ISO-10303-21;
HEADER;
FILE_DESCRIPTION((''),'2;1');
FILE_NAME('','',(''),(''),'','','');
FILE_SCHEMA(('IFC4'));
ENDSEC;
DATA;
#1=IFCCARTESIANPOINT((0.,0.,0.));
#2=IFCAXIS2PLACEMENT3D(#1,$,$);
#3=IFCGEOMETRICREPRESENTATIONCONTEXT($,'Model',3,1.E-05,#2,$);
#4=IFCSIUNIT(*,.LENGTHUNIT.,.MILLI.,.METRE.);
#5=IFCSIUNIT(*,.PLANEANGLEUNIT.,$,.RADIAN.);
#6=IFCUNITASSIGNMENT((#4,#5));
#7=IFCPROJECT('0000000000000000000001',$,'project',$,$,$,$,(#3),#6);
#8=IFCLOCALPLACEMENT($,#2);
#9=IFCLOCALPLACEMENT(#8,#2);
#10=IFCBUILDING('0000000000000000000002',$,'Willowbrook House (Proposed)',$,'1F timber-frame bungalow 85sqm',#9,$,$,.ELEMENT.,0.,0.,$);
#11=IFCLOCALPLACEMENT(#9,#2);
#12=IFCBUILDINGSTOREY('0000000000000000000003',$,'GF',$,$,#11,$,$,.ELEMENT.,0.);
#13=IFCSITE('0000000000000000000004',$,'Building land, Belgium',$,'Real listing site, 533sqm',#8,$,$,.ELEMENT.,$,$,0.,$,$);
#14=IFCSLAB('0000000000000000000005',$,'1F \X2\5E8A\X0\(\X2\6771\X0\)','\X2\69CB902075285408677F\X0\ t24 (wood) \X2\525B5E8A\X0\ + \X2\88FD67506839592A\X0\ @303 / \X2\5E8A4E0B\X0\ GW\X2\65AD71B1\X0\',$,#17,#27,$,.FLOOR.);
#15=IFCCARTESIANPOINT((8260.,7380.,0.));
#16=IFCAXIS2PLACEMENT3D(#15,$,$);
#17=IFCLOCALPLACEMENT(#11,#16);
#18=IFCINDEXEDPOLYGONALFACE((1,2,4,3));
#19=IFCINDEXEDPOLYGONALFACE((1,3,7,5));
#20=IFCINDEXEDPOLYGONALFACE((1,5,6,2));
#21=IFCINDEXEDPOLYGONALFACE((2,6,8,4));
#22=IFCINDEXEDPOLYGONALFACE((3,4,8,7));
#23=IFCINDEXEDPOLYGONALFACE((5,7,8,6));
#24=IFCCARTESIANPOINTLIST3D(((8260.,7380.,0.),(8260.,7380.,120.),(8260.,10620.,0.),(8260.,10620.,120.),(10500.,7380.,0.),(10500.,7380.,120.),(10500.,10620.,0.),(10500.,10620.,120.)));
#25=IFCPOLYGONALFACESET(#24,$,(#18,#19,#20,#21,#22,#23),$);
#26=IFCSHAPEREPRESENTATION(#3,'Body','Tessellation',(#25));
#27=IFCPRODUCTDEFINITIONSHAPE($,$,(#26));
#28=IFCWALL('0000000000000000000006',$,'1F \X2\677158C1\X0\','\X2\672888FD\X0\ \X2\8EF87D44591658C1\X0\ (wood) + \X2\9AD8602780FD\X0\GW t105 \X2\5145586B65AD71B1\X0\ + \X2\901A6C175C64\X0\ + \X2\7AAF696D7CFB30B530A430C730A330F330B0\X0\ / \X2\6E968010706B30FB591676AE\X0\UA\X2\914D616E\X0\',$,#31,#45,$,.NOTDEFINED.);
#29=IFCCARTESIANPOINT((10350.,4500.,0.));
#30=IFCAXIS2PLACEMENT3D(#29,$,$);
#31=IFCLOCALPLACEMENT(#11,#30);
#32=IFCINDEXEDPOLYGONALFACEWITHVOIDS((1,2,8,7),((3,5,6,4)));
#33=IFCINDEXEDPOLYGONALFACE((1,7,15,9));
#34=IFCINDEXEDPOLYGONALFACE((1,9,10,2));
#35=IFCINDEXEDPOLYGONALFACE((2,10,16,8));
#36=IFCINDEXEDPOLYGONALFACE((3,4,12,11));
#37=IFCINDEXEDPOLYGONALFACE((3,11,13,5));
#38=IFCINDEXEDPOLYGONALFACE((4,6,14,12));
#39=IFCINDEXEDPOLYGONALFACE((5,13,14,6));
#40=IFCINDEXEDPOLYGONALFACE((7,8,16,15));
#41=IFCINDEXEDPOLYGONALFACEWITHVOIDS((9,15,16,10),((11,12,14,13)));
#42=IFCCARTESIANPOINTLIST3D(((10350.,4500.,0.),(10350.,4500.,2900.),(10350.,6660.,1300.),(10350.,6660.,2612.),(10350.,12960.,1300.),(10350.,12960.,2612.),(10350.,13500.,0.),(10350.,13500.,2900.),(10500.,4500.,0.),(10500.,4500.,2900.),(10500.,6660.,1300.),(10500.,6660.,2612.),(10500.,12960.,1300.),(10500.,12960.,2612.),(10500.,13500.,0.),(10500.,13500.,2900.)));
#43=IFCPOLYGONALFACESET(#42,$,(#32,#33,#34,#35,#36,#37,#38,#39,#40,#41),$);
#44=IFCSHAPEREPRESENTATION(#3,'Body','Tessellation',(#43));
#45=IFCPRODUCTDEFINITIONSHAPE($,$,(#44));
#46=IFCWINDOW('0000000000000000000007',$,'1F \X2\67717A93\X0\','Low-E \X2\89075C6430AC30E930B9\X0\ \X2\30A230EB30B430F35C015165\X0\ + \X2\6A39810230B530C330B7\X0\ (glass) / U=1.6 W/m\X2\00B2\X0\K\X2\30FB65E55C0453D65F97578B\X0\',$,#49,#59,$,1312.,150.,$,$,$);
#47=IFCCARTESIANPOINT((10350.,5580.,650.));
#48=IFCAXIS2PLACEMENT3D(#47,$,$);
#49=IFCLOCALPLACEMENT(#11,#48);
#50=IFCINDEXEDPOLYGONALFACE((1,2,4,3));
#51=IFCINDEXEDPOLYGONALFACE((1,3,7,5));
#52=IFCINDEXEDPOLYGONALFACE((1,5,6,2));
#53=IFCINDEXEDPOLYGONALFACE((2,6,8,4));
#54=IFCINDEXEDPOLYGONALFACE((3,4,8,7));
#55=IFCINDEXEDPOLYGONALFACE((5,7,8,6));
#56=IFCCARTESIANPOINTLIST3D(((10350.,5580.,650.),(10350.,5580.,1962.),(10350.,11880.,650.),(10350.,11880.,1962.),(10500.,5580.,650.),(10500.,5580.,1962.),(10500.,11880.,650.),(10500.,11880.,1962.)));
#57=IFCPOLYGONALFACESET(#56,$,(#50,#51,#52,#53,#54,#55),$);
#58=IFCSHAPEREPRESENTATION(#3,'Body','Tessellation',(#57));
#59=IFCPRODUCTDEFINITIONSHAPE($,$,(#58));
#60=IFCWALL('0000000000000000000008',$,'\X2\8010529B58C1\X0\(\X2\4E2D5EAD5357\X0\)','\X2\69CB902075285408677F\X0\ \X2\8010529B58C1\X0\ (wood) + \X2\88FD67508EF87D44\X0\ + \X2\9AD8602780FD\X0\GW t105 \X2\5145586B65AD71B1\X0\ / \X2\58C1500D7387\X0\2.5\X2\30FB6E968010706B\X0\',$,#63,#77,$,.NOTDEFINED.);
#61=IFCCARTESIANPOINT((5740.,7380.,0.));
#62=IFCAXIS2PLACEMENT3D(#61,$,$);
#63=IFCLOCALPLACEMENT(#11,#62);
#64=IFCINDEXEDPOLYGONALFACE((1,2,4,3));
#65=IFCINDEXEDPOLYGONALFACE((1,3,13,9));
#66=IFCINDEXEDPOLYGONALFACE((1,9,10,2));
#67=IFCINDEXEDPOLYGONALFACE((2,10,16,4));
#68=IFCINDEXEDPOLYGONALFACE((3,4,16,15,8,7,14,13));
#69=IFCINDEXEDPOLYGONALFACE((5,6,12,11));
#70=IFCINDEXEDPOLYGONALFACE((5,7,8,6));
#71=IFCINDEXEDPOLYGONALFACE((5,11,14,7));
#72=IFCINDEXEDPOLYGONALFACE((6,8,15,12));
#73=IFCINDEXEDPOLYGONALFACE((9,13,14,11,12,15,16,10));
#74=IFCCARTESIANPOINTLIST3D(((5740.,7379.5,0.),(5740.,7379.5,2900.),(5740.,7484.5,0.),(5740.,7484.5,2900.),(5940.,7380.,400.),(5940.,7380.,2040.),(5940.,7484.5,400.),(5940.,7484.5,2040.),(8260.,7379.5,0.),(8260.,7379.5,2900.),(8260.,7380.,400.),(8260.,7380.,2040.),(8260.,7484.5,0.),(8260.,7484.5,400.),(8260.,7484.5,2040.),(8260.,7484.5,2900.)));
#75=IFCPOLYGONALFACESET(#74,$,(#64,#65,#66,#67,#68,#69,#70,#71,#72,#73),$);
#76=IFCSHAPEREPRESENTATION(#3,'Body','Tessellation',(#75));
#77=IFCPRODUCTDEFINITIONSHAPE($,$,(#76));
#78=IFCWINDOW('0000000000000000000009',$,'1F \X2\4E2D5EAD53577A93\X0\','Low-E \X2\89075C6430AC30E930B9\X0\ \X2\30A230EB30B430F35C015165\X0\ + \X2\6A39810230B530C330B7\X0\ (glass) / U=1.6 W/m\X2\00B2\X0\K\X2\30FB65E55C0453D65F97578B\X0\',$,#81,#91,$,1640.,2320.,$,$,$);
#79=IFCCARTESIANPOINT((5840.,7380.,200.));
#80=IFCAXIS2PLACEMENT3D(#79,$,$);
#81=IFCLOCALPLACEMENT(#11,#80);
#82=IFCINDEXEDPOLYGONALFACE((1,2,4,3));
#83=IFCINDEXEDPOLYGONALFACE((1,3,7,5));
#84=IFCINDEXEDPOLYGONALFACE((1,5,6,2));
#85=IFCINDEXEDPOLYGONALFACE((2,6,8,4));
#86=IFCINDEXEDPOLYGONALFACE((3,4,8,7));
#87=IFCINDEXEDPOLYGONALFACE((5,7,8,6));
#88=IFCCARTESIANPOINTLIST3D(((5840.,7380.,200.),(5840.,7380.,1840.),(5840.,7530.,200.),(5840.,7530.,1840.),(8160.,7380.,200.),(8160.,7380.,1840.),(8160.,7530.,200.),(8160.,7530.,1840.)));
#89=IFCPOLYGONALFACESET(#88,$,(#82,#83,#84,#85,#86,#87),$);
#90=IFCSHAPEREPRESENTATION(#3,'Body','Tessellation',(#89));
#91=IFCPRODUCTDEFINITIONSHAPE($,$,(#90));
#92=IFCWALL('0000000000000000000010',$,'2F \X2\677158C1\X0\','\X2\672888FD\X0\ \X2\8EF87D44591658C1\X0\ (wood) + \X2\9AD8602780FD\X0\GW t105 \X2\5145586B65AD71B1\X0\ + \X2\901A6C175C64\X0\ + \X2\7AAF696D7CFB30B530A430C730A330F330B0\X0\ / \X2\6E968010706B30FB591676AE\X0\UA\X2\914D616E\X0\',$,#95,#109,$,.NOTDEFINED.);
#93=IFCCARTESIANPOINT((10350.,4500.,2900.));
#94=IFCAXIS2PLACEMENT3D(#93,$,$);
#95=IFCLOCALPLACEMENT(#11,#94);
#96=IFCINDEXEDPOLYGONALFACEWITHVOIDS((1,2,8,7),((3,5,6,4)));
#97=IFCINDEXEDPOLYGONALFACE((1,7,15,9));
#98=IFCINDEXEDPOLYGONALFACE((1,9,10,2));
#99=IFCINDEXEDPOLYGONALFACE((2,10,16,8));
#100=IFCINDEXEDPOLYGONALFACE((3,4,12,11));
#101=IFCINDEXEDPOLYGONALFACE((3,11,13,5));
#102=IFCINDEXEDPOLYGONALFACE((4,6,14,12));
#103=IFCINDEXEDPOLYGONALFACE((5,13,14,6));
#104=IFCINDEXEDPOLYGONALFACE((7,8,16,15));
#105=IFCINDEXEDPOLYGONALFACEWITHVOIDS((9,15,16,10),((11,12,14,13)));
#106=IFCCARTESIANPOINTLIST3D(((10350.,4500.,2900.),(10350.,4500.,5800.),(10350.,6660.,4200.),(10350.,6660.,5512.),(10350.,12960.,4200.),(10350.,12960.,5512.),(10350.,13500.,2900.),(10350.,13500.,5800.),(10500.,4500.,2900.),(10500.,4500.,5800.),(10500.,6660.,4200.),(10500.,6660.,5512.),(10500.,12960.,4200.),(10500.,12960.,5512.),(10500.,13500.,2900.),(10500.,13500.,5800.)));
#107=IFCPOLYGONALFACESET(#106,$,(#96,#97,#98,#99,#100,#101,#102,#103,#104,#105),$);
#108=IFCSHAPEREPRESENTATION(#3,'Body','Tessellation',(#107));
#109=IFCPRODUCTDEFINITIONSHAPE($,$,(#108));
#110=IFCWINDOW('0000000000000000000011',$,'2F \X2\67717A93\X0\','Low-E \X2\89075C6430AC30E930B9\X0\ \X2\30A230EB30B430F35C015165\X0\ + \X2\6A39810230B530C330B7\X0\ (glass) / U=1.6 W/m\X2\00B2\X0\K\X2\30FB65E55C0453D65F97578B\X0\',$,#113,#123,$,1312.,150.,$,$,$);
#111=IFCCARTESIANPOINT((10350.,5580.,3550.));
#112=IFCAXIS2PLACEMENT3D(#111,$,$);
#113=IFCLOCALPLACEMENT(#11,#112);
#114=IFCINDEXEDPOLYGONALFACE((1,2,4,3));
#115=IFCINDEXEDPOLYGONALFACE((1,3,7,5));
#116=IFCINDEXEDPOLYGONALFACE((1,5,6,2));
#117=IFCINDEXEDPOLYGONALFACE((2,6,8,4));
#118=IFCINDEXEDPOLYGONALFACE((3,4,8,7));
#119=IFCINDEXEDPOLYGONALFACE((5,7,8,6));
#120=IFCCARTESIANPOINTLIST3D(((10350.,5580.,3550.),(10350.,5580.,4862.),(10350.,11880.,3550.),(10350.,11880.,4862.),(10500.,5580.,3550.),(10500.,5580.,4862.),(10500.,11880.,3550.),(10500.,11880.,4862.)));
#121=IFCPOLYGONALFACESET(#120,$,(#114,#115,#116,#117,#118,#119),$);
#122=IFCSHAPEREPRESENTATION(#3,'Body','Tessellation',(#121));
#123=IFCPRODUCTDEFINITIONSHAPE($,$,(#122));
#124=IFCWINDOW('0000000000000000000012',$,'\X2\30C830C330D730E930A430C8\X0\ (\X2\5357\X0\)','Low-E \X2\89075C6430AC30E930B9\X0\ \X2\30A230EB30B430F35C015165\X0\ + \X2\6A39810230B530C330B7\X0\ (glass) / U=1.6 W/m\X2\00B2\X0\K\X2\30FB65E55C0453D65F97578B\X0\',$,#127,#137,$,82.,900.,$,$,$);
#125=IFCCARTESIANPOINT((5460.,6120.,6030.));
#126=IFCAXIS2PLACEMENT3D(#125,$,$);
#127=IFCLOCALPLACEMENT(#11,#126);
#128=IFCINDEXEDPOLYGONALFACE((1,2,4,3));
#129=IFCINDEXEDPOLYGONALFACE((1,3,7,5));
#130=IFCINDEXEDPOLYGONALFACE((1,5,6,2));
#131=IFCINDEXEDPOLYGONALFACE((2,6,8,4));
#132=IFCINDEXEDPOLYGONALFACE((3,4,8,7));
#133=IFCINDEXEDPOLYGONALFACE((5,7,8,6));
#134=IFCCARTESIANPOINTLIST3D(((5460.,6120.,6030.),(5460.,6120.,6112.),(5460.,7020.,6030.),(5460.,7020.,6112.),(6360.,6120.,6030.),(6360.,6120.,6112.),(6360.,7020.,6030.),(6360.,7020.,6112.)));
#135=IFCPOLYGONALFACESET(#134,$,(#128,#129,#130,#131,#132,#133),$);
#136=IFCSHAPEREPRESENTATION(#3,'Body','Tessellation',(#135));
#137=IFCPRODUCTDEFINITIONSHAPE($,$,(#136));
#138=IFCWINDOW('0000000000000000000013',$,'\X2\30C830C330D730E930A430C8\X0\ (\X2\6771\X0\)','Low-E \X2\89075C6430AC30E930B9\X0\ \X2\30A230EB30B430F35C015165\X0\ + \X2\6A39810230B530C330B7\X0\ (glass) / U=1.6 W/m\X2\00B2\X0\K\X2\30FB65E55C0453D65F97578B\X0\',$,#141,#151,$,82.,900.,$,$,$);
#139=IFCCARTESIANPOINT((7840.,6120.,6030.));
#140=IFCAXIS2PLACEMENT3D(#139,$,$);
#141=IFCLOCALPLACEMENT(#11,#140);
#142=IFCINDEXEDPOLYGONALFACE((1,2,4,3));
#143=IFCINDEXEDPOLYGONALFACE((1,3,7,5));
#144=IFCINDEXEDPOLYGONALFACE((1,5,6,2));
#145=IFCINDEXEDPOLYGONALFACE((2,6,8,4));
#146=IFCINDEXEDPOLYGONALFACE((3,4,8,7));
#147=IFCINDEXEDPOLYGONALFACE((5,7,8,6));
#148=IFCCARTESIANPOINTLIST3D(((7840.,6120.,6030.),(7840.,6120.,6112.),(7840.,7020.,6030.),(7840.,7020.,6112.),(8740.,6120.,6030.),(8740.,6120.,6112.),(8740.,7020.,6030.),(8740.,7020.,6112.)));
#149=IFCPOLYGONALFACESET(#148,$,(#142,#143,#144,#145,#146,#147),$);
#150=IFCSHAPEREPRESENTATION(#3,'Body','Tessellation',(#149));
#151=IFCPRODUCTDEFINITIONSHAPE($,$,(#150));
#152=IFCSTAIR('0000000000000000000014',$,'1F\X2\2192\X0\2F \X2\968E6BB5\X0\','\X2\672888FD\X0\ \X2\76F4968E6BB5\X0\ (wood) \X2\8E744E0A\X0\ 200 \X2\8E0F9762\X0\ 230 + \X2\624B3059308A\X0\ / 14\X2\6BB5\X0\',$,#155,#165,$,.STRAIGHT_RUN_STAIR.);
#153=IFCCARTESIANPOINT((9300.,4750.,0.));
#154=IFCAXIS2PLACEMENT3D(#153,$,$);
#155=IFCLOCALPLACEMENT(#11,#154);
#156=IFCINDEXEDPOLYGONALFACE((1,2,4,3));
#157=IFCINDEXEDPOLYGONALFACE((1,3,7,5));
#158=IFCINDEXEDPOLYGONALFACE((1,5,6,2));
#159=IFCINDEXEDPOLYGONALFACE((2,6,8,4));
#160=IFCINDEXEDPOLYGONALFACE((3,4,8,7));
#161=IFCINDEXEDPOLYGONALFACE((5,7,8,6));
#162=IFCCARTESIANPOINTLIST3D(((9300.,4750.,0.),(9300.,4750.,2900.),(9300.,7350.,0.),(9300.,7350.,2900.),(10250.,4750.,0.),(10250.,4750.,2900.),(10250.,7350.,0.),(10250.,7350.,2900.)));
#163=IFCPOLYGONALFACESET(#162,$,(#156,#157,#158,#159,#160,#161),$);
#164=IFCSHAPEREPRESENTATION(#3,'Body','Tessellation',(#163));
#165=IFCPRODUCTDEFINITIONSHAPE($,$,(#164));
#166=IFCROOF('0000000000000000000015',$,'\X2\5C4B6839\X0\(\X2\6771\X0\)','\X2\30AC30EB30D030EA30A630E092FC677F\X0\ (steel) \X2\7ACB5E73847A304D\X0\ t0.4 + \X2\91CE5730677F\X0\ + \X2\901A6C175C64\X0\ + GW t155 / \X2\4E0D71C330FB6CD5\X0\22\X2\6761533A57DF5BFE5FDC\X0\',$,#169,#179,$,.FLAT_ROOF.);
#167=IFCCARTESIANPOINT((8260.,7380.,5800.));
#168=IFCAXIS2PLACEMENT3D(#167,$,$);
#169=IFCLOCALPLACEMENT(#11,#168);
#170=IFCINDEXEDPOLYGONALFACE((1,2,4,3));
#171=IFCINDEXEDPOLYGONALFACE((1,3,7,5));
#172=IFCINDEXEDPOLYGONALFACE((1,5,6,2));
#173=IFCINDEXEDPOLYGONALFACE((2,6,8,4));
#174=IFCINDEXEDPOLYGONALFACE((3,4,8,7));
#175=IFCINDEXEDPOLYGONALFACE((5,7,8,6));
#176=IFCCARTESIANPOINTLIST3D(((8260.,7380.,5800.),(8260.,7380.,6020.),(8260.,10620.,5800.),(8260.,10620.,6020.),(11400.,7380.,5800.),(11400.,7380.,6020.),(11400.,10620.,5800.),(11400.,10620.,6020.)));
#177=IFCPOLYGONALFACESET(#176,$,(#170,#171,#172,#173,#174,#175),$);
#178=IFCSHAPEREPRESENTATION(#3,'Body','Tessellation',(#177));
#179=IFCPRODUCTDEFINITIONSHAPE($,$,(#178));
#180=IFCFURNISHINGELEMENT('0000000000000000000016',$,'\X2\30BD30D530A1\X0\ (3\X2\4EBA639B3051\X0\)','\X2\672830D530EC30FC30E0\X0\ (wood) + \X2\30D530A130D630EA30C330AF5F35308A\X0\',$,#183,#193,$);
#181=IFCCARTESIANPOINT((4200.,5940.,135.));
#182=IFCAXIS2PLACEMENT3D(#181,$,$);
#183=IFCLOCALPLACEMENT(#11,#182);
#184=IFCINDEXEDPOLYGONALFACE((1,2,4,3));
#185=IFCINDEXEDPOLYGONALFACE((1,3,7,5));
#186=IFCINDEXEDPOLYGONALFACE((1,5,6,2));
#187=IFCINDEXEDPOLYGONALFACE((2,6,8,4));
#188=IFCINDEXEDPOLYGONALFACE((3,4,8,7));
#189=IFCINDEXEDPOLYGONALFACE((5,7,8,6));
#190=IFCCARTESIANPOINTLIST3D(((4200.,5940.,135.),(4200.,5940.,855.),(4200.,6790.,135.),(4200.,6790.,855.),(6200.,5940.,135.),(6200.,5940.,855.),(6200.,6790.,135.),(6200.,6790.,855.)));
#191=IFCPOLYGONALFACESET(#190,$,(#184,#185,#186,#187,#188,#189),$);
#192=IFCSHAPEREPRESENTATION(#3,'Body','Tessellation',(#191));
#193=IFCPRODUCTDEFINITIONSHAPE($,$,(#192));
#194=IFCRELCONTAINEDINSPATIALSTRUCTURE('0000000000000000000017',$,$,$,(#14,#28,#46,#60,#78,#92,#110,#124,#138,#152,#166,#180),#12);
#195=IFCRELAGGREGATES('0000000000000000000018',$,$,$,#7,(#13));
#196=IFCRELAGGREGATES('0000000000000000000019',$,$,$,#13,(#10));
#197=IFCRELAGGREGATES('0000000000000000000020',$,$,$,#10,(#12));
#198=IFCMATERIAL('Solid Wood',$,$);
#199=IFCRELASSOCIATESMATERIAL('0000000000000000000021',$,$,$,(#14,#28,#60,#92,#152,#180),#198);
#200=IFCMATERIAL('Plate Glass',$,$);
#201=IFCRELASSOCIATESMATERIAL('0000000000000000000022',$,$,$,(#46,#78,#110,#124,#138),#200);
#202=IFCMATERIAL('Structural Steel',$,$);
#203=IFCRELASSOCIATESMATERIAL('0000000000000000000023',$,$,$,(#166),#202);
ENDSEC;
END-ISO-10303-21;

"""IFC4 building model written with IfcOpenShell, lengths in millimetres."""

from ifc_helpers import new_model, si_unit, frame, frame_2d, origin, place, context, project, spatial, rectangle, extrude, material, element, fill, save


model = new_model("IFC4")

# Units and contexts
model_context = context("Model", 3, precision=1e-05, world=origin())
ifc_project = project(units=[si_unit("LENGTHUNIT", "METRE", prefix="MILLI"), si_unit("PLANEANGLEUNIT", "RADIAN")], contexts=[model_context])

# Site, building, storey
site_placement = place(None, origin())
site = spatial("IfcSite", under=ifc_project, at=site_placement, Name="Building land, Belgium", ObjectType="Real listing site, 533sqm", CompositionType="ELEMENT", RefElevation=0.0)
building_placement = place(site_placement, origin())
building = spatial("IfcBuilding", under=site, at=building_placement, Name="Willowbrook House (Proposed)", ObjectType="1F timber-frame bungalow 85sqm", CompositionType="ELEMENT", ElevationOfRefHeight=0.0, ElevationOfTerrain=0.0)
storey_placement = place(building_placement, origin())
storey = spatial("IfcBuildingStorey", under=building, at=storey_placement, Name="GF", CompositionType="ELEMENT", Elevation=0.0)

# Slab
ifc_material_1 = material(Name="Solid Wood")
slab_placement = place(storey_placement, frame((8260.0, 7380.0, 0.0)))
element("IfcSlab", 1, at=slab_placement, inside=storey, material=ifc_material_1, Name="1F 床(東)", Description="構造用合板 t24 (wood) 剛床 + 製材根太 @303 / 床下 GW断熱", PredefinedType="FLOOR", context=model_context, shape_type="SweptSolid", body=[
    extrude(rectangle(XDim=2240.0, YDim=3240.0, at=frame_2d((1120.0, 1620.0))), frame((8260.0, 7380.0, 0.0)), (0.0, 0.0, 1.0), 120.0),
])

# Walls, openings, windows
wall_1_placement = place(storey_placement, frame((10350.0, 4500.0, 0.0)))
wall_1 = element("IfcWall", 2, at=wall_1_placement, inside=storey, material=ifc_material_1, Name="1F 東壁", Description="木製 軸組外壁 (wood) + 高性能GW t105 充填断熱 + 通気層 + 窯業系サイディング / 準耐火・外皮UA配慮", PredefinedType="NOTDEFINED", context=model_context, shape_type="SweptSolid", body=[
    extrude(rectangle(XDim=150.0, YDim=9000.0, at=frame_2d((75.0, 4500.0))), frame((10350.0, 4500.0, 0.0)), (0.0, 0.0, 1.0), 2900.0),
])
opening_1_placement = place(storey_placement, frame((10350.0, 5580.0, 650.0)))
opening_1 = element("IfcOpeningElement", 3, at=opening_1_placement, cuts=wall_1, PredefinedType="NOTDEFINED", context=model_context, shape_type="SweptSolid", body=[
    extrude(rectangle(XDim=150.0, YDim=6300.0, at=frame_2d((75.0, 3150.0))), frame((10350.0, 5580.0, 650.0)), (0.0, 0.0, 1.0), 1312.0),
])
ifc_material_2 = material(Name="Plate Glass")
window_1_placement = place(storey_placement, frame((10350.0, 5580.0, 650.0)))
window_1 = element("IfcWindow", 4, at=window_1_placement, inside=storey, material=ifc_material_2, Name="1F 東窓", Description="Low-E 複層ガラス アルゴン封入 + 樹脂サッシ (glass) / U=1.6 W/m²K・日射取得型", OverallHeight=1312.0, OverallWidth=150.0, context=model_context, shape_type="SweptSolid", body=[
    extrude(rectangle(XDim=150.0, YDim=6300.0, at=frame_2d((75.0, 3150.0))), frame((10350.0, 5580.0, 650.0)), (0.0, 0.0, 1.0), 1312.0),
])
fill(opening_1, window_1)
wall_2_placement = place(storey_placement, frame((5740.0, 7380.0, 0.0)))
wall_2 = element("IfcWall", 5, at=wall_2_placement, inside=storey, material=ifc_material_1, Name="耐力壁(中庭南)", Description="構造用合板 耐力壁 (wood) + 製材軸組 + 高性能GW t105 充填断熱 / 壁倍率2.5・準耐火", PredefinedType="NOTDEFINED", context=model_context, shape_type="SweptSolid", body=[
    extrude(rectangle(XDim=2520.0, YDim=105.0, at=frame_2d((1260.0, 52.0))), frame((5740.0, 7380.0, 0.0)), (0.0, 0.0, 1.0), 2900.0),
])
opening_2_placement = place(storey_placement, frame((5840.0, 7380.0, 200.0)))
opening_2 = element("IfcOpeningElement", 6, at=opening_2_placement, cuts=wall_2, PredefinedType="NOTDEFINED", context=model_context, shape_type="SweptSolid", body=[
    extrude(rectangle(XDim=2320.0, YDim=150.0, at=frame_2d((1160.0, 75.0))), frame((5840.0, 7380.0, 200.0)), (0.0, 0.0, 1.0), 1640.0),
])
window_2_placement = place(storey_placement, frame((5840.0, 7380.0, 200.0)))
window_2 = element("IfcWindow", 7, at=window_2_placement, inside=storey, material=ifc_material_2, Name="1F 中庭南窓", Description="Low-E 複層ガラス アルゴン封入 + 樹脂サッシ (glass) / U=1.6 W/m²K・日射取得型", OverallHeight=1640.0, OverallWidth=2320.0, context=model_context, shape_type="SweptSolid", body=[
    extrude(rectangle(XDim=2320.0, YDim=150.0, at=frame_2d((1160.0, 75.0))), frame((5840.0, 7380.0, 200.0)), (0.0, 0.0, 1.0), 1640.0),
])
fill(opening_2, window_2)

# Wall, opening, window
wall_3_placement = place(storey_placement, frame((10350.0, 4500.0, 2900.0)))
wall_3 = element("IfcWall", 8, at=wall_3_placement, inside=storey, material=ifc_material_1, Name="2F 東壁", Description="木製 軸組外壁 (wood) + 高性能GW t105 充填断熱 + 通気層 + 窯業系サイディング / 準耐火・外皮UA配慮", PredefinedType="NOTDEFINED", context=model_context, shape_type="SweptSolid", body=[
    extrude(rectangle(XDim=150.0, YDim=9000.0, at=frame_2d((75.0, 4500.0))), frame((10350.0, 4500.0, 2900.0)), (0.0, 0.0, 1.0), 2900.0),
])
opening_3_placement = place(storey_placement, frame((10350.0, 5580.0, 3550.0)))
opening_3 = element("IfcOpeningElement", 9, at=opening_3_placement, cuts=wall_3, PredefinedType="NOTDEFINED", context=model_context, shape_type="SweptSolid", body=[
    extrude(rectangle(XDim=150.0, YDim=6300.0, at=frame_2d((75.0, 3150.0))), frame((10350.0, 5580.0, 3550.0)), (0.0, 0.0, 1.0), 1312.0),
])
window_3_placement = place(storey_placement, frame((10350.0, 5580.0, 3550.0)))
window_3 = element("IfcWindow", 10, at=window_3_placement, inside=storey, material=ifc_material_2, Name="2F 東窓", Description="Low-E 複層ガラス アルゴン封入 + 樹脂サッシ (glass) / U=1.6 W/m²K・日射取得型", OverallHeight=1312.0, OverallWidth=150.0, context=model_context, shape_type="SweptSolid", body=[
    extrude(rectangle(XDim=150.0, YDim=6300.0, at=frame_2d((75.0, 3150.0))), frame((10350.0, 5580.0, 3550.0)), (0.0, 0.0, 1.0), 1312.0),
])
fill(opening_3, window_3)

# Windows
window_4_placement = place(storey_placement, frame((5460.0, 6120.0, 6030.0)))
element("IfcWindow", 11, at=window_4_placement, inside=storey, material=ifc_material_2, Name="トップライト (南)", Description="Low-E 複層ガラス アルゴン封入 + 樹脂サッシ (glass) / U=1.6 W/m²K・日射取得型", OverallHeight=82.0, OverallWidth=900.0, context=model_context, shape_type="SweptSolid", body=[
    extrude(rectangle(XDim=900.0, YDim=900.0, at=frame_2d((450.0, 450.0))), frame((5460.0, 6120.0, 6030.0)), (0.0, 0.0, 1.0), 82.0),
])
window_5_placement = place(storey_placement, frame((7840.0, 6120.0, 6030.0)))
element("IfcWindow", 12, at=window_5_placement, inside=storey, material=ifc_material_2, Name="トップライト (東)", Description="Low-E 複層ガラス アルゴン封入 + 樹脂サッシ (glass) / U=1.6 W/m²K・日射取得型", OverallHeight=82.0, OverallWidth=900.0, context=model_context, shape_type="SweptSolid", body=[
    extrude(rectangle(XDim=900.0, YDim=900.0, at=frame_2d((450.0, 450.0))), frame((7840.0, 6120.0, 6030.0)), (0.0, 0.0, 1.0), 82.0),
])

# Stair
stair_placement = place(storey_placement, frame((9300.0, 4750.0, 0.0)))
element("IfcStair", 13, at=stair_placement, inside=storey, material=ifc_material_1, Name="1F→2F 階段", Description="木製 直階段 (wood) 蹴上 200 踏面 230 + 手すり / 14段", PredefinedType="STRAIGHT_RUN_STAIR", context=model_context, shape_type="SweptSolid", body=[
    extrude(rectangle(XDim=950.0, YDim=2600.0, at=frame_2d((475.0, 1300.0))), frame((9300.0, 4750.0, 0.0)), (0.0, 0.0, 1.0), 2900.0),
])

# Roof
ifc_material_3 = material(Name="Structural Steel")
roof_placement = place(storey_placement, frame((8260.0, 7380.0, 5800.0)))
element("IfcRoof", 14, at=roof_placement, inside=storey, material=ifc_material_3, Name="屋根(東)", Description="ガルバリウム鋼板 (steel) 立平葺き t0.4 + 野地板 + 通気層 + GW t155 / 不燃・法22条区域対応", PredefinedType="FLAT_ROOF", context=model_context, shape_type="SweptSolid", body=[
    extrude(rectangle(XDim=3140.0, YDim=3240.0, at=frame_2d((1570.0, 1620.0))), frame((8260.0, 7380.0, 5800.0)), (0.0, 0.0, 1.0), 220.0),
])

# Furnishing element
furnishing_1_placement = place(storey_placement, frame((4200.0, 5940.0, 135.0)))
element("IfcFurnishingElement", 15, at=furnishing_1_placement, inside=storey, material=ifc_material_1, Name="ソファ (3人掛け)", Description="木フレーム (wood) + ファブリック張り", context=model_context, shape_type="SweptSolid", body=[
    extrude(rectangle(XDim=2000.0, YDim=850.0, at=frame_2d((1000.0, 425.0))), frame((4200.0, 5940.0, 135.0)), (0.0, 0.0, 1.0), 720.0),
])

save(model, "model.ifc")
